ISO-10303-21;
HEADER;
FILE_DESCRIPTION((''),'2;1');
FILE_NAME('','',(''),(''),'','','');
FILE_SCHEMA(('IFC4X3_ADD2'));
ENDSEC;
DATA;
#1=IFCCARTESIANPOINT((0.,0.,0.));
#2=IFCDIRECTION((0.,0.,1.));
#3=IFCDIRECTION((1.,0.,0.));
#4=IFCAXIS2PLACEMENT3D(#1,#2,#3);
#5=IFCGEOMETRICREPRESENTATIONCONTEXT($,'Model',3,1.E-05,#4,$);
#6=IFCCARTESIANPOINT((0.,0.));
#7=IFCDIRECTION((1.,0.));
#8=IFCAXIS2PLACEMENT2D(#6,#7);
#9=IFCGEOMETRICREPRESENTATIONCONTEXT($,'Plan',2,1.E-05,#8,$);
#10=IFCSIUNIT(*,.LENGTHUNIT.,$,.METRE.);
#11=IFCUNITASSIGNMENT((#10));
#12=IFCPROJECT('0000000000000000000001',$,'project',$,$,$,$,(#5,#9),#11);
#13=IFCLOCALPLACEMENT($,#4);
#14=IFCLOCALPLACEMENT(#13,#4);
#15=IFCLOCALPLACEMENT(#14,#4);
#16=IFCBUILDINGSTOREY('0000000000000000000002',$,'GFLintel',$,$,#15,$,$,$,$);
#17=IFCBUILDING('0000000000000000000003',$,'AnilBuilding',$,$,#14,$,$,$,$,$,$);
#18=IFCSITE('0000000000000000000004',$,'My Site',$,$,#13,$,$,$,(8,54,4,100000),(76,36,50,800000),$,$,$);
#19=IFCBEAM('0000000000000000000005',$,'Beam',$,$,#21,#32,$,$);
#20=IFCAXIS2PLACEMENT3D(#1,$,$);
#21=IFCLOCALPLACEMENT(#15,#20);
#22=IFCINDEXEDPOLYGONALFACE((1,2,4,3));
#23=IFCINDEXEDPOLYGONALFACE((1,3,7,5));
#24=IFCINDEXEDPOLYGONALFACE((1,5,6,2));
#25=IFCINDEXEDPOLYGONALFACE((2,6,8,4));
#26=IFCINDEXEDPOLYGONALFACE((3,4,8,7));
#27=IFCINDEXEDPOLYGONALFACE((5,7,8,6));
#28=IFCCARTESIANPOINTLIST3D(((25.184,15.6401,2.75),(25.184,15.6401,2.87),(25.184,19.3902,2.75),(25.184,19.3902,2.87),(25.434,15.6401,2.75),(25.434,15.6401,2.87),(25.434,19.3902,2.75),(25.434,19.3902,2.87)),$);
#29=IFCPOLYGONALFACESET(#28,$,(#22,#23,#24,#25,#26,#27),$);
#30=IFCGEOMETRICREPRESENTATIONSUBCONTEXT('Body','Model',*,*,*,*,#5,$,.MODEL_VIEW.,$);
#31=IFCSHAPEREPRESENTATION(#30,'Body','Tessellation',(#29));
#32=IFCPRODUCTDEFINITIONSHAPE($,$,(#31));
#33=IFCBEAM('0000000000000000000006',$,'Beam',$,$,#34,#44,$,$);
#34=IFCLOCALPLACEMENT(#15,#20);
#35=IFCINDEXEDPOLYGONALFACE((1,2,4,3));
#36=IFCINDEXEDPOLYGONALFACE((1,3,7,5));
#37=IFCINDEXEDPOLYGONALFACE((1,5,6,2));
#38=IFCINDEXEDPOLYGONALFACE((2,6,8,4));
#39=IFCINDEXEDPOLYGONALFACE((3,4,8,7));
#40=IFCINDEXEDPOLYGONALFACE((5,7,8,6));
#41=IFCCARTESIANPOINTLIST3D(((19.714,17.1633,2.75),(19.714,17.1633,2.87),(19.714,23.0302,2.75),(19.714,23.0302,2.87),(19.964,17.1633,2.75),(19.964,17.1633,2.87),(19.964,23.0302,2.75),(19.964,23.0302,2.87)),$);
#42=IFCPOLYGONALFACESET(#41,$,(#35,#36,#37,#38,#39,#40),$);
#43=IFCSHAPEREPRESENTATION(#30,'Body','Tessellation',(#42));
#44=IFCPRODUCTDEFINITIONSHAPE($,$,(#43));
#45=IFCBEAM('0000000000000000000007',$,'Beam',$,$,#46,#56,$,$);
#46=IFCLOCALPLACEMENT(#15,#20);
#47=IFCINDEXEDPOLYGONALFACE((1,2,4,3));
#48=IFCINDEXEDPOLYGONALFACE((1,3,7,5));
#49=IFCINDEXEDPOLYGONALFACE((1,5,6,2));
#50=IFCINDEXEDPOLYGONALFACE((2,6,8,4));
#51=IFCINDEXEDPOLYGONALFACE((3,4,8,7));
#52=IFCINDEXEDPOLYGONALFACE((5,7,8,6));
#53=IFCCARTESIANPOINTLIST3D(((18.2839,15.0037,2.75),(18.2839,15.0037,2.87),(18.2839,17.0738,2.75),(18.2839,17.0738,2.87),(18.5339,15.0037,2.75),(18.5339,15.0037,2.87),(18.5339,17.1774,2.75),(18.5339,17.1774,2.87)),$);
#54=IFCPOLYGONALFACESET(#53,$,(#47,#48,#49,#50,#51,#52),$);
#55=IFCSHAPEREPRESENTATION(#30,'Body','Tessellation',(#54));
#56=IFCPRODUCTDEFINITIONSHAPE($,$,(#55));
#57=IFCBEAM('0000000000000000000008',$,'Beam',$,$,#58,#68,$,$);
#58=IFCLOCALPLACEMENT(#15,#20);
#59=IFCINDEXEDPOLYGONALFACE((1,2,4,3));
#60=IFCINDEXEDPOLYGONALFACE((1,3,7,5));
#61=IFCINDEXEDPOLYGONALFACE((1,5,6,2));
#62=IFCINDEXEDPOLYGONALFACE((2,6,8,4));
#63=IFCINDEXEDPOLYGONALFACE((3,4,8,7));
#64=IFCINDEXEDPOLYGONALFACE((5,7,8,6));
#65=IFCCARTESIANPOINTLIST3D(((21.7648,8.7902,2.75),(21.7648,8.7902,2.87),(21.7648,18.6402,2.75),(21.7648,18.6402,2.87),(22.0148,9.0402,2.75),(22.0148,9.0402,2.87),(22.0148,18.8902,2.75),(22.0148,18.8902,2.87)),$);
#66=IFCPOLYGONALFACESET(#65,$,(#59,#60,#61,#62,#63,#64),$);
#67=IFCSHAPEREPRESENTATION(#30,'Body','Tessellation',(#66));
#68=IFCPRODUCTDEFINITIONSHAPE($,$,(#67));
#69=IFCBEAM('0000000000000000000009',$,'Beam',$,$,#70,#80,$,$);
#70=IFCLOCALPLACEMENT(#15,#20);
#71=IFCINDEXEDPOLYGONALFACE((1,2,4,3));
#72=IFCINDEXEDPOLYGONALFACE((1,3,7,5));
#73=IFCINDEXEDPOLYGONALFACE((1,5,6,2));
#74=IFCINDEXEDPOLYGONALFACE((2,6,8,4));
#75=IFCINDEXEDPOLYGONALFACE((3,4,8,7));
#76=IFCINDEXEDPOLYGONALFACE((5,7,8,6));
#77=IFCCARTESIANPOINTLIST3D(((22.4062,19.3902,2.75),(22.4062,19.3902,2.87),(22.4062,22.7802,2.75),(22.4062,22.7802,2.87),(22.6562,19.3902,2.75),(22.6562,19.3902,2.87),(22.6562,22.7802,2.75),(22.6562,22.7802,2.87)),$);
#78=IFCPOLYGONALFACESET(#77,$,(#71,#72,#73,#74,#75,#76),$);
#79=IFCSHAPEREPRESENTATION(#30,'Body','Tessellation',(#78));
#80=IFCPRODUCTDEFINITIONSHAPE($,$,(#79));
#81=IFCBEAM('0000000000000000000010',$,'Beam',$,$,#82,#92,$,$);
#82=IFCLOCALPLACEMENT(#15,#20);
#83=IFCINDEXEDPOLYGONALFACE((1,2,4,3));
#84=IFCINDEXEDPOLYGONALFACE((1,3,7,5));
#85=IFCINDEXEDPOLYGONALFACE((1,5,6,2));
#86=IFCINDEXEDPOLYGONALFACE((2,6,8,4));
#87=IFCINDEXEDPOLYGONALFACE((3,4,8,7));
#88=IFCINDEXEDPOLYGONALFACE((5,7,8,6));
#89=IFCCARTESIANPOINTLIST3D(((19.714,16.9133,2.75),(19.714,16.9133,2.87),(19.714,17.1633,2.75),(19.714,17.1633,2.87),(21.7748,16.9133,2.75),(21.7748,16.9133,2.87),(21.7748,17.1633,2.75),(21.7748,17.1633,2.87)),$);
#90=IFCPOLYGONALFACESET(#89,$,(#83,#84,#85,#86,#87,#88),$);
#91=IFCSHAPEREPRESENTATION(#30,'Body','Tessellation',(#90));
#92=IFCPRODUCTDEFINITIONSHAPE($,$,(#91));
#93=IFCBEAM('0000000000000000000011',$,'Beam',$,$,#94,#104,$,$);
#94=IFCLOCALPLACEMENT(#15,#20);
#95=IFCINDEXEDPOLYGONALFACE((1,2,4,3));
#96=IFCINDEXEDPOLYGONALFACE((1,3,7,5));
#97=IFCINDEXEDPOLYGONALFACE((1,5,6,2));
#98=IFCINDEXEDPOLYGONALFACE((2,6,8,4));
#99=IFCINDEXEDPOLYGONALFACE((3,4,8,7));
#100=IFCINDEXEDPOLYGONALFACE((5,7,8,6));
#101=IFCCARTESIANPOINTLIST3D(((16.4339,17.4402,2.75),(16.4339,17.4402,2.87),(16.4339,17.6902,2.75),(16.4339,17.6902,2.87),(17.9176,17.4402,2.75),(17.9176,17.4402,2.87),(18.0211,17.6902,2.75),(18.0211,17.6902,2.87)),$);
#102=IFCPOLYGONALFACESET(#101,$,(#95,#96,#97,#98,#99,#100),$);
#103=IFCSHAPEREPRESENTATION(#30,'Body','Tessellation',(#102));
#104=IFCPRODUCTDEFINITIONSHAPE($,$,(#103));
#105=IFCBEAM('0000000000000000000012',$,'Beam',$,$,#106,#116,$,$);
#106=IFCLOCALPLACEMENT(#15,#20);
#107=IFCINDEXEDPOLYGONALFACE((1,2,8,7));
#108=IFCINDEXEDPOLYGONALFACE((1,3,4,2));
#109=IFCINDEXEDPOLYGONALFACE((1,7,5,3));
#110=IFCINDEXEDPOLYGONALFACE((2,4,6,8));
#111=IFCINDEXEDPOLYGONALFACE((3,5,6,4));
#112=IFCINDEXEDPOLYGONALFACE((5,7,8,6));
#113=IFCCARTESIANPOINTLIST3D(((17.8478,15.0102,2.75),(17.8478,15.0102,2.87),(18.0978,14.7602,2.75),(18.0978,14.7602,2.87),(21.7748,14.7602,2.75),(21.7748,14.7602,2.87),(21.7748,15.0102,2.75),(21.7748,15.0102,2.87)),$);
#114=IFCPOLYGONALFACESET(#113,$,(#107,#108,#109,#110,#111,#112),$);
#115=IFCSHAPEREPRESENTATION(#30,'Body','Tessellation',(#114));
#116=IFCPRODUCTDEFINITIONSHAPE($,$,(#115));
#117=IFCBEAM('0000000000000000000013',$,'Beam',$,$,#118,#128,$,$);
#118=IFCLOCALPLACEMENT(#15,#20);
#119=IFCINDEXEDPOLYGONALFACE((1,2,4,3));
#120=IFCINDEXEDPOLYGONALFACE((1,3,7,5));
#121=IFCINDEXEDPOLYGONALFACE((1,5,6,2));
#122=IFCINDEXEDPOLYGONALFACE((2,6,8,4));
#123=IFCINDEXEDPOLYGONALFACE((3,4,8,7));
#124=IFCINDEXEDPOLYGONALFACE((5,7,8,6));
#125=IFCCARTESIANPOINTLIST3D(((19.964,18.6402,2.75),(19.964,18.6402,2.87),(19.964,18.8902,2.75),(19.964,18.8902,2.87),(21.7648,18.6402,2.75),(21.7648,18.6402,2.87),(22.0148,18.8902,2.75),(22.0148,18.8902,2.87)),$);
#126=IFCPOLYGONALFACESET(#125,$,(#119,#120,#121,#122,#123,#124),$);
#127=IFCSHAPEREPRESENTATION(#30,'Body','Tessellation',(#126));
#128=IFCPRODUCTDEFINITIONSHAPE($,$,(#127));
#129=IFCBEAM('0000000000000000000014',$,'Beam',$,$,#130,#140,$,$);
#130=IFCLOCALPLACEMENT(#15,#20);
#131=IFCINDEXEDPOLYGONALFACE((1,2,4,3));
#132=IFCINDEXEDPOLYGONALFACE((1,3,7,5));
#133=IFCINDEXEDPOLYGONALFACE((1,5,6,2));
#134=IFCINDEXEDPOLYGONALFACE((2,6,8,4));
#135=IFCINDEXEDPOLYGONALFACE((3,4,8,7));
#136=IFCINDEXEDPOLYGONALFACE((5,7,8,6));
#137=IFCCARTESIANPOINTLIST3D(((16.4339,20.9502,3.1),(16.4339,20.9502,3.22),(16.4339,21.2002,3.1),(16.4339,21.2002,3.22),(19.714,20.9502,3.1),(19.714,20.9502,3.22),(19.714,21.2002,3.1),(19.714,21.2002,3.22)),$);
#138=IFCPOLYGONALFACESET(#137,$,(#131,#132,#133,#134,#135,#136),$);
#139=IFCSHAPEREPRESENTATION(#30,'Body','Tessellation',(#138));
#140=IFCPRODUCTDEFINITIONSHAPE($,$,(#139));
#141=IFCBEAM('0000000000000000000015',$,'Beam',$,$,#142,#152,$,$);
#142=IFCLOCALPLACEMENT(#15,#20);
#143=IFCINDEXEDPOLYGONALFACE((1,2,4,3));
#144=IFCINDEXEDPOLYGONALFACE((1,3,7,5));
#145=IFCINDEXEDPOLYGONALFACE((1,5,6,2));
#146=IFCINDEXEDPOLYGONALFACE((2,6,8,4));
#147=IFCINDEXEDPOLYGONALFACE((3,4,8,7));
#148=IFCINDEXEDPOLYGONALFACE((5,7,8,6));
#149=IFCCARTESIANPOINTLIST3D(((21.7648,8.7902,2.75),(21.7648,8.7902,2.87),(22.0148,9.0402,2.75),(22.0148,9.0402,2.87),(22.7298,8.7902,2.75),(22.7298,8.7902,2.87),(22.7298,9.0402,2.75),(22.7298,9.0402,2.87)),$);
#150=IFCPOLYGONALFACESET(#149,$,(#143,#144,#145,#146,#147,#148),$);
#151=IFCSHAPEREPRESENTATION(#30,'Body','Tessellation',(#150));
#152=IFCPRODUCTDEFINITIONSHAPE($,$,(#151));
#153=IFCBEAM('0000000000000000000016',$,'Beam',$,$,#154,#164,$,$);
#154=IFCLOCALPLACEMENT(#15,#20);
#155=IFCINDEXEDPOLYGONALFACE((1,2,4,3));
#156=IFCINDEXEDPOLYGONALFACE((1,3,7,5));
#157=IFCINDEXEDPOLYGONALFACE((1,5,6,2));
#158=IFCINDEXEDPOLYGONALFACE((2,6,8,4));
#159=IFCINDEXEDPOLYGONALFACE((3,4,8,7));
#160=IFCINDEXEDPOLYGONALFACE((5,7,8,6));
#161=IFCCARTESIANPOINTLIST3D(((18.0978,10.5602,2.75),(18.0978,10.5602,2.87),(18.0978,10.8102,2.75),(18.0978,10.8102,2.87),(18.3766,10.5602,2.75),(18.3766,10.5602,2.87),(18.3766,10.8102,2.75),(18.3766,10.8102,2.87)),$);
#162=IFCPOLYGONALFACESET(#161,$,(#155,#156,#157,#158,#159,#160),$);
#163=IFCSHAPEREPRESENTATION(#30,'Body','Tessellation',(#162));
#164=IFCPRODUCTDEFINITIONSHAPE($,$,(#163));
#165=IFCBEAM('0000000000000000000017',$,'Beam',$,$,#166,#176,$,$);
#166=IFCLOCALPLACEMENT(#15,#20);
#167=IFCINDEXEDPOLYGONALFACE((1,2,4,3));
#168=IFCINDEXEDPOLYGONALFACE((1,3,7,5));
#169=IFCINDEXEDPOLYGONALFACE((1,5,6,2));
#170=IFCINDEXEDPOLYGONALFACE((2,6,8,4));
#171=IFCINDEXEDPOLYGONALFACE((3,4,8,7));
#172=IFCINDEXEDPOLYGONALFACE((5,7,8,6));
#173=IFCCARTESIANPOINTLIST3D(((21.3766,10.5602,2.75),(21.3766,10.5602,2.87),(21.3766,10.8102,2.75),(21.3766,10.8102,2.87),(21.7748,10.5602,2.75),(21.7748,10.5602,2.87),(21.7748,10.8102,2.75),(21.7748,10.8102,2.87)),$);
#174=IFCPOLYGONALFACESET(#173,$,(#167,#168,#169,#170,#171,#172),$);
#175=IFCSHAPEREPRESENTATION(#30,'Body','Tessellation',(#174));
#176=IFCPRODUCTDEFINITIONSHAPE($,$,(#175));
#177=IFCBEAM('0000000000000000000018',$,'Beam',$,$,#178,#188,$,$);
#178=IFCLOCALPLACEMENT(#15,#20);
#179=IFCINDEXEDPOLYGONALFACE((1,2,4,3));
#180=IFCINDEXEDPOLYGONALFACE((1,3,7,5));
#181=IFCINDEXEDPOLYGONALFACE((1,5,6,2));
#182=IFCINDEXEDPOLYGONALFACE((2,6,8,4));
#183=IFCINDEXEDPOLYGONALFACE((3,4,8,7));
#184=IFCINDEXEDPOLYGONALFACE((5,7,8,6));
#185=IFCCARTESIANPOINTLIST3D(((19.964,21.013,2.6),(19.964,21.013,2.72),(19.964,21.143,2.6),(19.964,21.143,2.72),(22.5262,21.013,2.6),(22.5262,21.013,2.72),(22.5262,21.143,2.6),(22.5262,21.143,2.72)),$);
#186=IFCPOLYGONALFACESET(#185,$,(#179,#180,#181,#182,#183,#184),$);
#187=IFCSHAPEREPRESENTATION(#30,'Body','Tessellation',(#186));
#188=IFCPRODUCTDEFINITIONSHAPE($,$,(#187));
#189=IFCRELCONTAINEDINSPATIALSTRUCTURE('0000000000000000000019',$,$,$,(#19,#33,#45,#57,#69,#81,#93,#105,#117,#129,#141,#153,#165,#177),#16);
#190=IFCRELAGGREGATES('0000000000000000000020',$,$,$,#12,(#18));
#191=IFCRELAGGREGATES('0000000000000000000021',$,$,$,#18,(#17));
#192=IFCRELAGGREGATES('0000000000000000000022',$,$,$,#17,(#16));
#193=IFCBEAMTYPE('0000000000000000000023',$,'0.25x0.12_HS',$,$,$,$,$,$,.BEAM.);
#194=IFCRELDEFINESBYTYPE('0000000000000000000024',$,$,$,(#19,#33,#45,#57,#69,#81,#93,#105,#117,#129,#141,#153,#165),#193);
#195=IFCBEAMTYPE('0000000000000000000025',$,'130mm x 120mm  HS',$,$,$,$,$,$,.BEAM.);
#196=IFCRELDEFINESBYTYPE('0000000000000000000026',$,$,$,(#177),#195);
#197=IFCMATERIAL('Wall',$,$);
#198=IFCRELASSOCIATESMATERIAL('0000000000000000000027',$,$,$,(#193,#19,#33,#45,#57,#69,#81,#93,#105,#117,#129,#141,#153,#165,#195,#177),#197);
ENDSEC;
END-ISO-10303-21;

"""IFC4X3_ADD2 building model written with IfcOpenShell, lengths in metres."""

from ifc_helpers import new_model, si_unit, frame, origin_with_axes, origin_2d_with_axis, place, context, subcontext, project, spatial, rectangle, extrude, clip, halfspace, material, material_profile, profile_set, profile_usage, type_object, element, save


model = new_model("IFC4X3_ADD2")

# Units and contexts
model_context = context("Model", 3, precision=1e-05, world=origin_with_axes())
plan_context = context("Plan", 2, precision=1e-05, world=origin_2d_with_axis())
body_context = subcontext(model_context, "Body", "Model", "MODEL_VIEW")
ifc_project = project(units=[si_unit("LENGTHUNIT", "METRE")], contexts=[model_context, plan_context])

# Site, building, storey
site_placement = place(None, origin_with_axes())
site = spatial("IfcSite", under=ifc_project, at=site_placement, Name="My Site", RefLatitude=(8, 54, 4, 100000), RefLongitude=(76, 36, 50, 800000))
building_placement = place(site_placement, origin_with_axes())
building = spatial("IfcBuilding", under=site, at=building_placement, Name="AnilBuilding")
storey_placement = place(building_placement, origin_with_axes())
storey = spatial("IfcBuildingStorey", under=building, at=storey_placement, Name="GFLintel")

# Beams
ifc_material_1 = material(Name="Wall")
ifc_material_profile_1 = material_profile(ifc_material_1, rectangle(XDim=0.25, YDim=0.12))
ifc_profile_set_1 = profile_set([ifc_material_profile_1], Name="concrete")
ifc_profile_usage_1 = profile_usage(ifc_profile_set_1)
beam_type_1 = type_object("IfcBeamType", Name="0.25x0.12_HS", PredefinedType="BEAM", material=ifc_profile_set_1)
beam_1_placement = place(storey_placement, frame((25.309, 19.3902, 2.81), z_axis=(0.0, -1.0, 0.0), x_axis=(1.0, 0.0, 0.0)))
element("IfcBeam", 1, at=beam_1_placement, inside=storey, type_object=beam_type_1, material=ifc_profile_usage_1, Name="Beam", context=body_context, shape_type="SweptSolid", body=[
    extrude(rectangle(XDim=0.25, YDim=0.12), origin_with_axes(), (0.0, 0.0, 1.0), 3.7501),
])
ifc_profile_usage_2 = profile_usage(ifc_profile_set_1)
beam_2_placement = place(storey_placement, frame((19.839, 23.0302, 2.81), z_axis=(0.0, -1.0, 0.0), x_axis=(1.0, 0.0, 0.0)))
element("IfcBeam", 2, at=beam_2_placement, inside=storey, type_object=beam_type_1, material=ifc_profile_usage_2, Name="Beam", context=body_context, shape_type="SweptSolid", body=[
    extrude(rectangle(XDim=0.25, YDim=0.12), origin_with_axes(), (0.0, 0.0, 1.0), 5.8669),
])
ifc_profile_usage_3 = profile_usage(ifc_profile_set_1)
beam_3_placement = place(storey_placement, frame((18.4089, 17.5524, 2.81), z_axis=(0.0, -1.0, 0.0), x_axis=(1.0, 0.0, 0.0)))
element("IfcBeam", 3, at=beam_3_placement, inside=storey, type_object=beam_type_1, material=ifc_profile_usage_3, Name="Beam", context=body_context, shape_type="Clipping", body=[
    clip(extrude(rectangle(XDim=0.25, YDim=0.12), origin_with_axes(), (0.0, 0.0, 1.0), 2.5487), halfspace(frame((0.125, -2.81, 0.375), z_axis=(-0.382687, 0.0, -0.923878), x_axis=(0.000001, 1.0, 0.0)), False)),
])
ifc_profile_usage_4 = profile_usage(ifc_profile_set_1)
beam_4_placement = place(storey_placement, frame((21.8898, 18.8902, 2.81), z_axis=(0.0, -1.0, 0.0), x_axis=(1.0, 0.0, 0.0)))
element("IfcBeam", 4, at=beam_4_placement, inside=storey, type_object=beam_type_1, material=ifc_profile_usage_4, Name="Beam", context=body_context, shape_type="Clipping", body=[
    clip(clip(extrude(rectangle(XDim=0.25, YDim=0.12), origin_with_axes(), (0.0, 0.0, 1.0), 10.1), halfspace(frame((-0.125, -2.66, 10.1), z_axis=(0.707107, 0.0, 0.707107), x_axis=(0.0, -1.0, 0.0)), False)), halfspace(frame((0.125, -2.66, 0.0), z_axis=(-0.707104, 0.0, -0.707109), x_axis=(0.0, 1.0, 0.0)), False)),
])
ifc_profile_usage_5 = profile_usage(ifc_profile_set_1)
beam_5_placement = place(storey_placement, frame((22.5312, 19.3902, 2.81), z_axis=(0.000001, 1.0, 0.0), x_axis=(-1.0, 0.000001, 0.0)))
element("IfcBeam", 5, at=beam_5_placement, inside=storey, type_object=beam_type_1, material=ifc_profile_usage_5, Name="Beam", context=body_context, shape_type="SweptSolid", body=[
    extrude(rectangle(XDim=0.25, YDim=0.12), origin_with_axes(), (0.0, 0.0, 1.0), 3.39),
])
ifc_profile_usage_6 = profile_usage(ifc_profile_set_1)
beam_6_placement = place(storey_placement, frame((21.7748, 17.0383, 2.81), z_axis=(-1.0, 0.0, 0.0), x_axis=(0.0, -1.0, 0.0)))
element("IfcBeam", 6, at=beam_6_placement, inside=storey, type_object=beam_type_1, material=ifc_profile_usage_6, Name="Beam", context=body_context, shape_type="SweptSolid", body=[
    extrude(rectangle(XDim=0.25, YDim=0.12), origin_with_axes(), (0.0, 0.0, 1.0), 2.0608),
])
ifc_profile_usage_7 = profile_usage(ifc_profile_set_1)
beam_7_placement = place(storey_placement, frame((18.3961, 17.5652, 2.81), z_axis=(-1.0, 0.0, 0.0), x_axis=(0.0, -1.0, 0.0)))
element("IfcBeam", 7, at=beam_7_placement, inside=storey, type_object=beam_type_1, material=ifc_profile_usage_7, Name="Beam", context=body_context, shape_type="Clipping", body=[
    clip(extrude(rectangle(XDim=0.25, YDim=0.12), origin_with_axes(), (0.0, 0.0, 1.0), 1.9622), halfspace(frame((-0.125, -2.81, 0.375), z_axis=(0.382685, 0.000001, -0.923879), x_axis=(0.000002, -1.0, 0.0)), False)),
])
ifc_profile_usage_8 = profile_usage(ifc_profile_set_1)
beam_8_placement = place(storey_placement, frame((21.7748, 14.8852, 2.81), z_axis=(-1.0, 0.0, 0.0), x_axis=(0.0, -1.0, 0.0)))
element("IfcBeam", 8, at=beam_8_placement, inside=storey, type_object=beam_type_1, material=ifc_profile_usage_8, Name="Beam", context=body_context, shape_type="Clipping", body=[
    clip(extrude(rectangle(XDim=0.25, YDim=0.12), origin_with_axes(), (0.0, 0.0, 1.0), 3.927), halfspace(frame((-0.125, -2.81, 3.927), z_axis=(0.707107, 0.0, 0.707107), x_axis=(0.0, -1.0, 0.0)), False)),
])
ifc_profile_usage_9 = profile_usage(ifc_profile_set_1)
beam_9_placement = place(storey_placement, frame((22.0148, 18.7652, 2.81), z_axis=(-1.0, 0.0, 0.0), x_axis=(0.0, -1.0, 0.0)))
element("IfcBeam", 9, at=beam_9_placement, inside=storey, type_object=beam_type_1, material=ifc_profile_usage_9, Name="Beam", context=body_context, shape_type="Clipping", body=[
    clip(extrude(rectangle(XDim=0.25, YDim=0.12), origin_with_axes(), (0.0, 0.0, 1.0), 2.0508), halfspace(frame((-0.125, -2.66, 0.0), z_axis=(0.70711, 0.0, -0.707104), x_axis=(0.0, -1.0, 0.0)), False)),
])
ifc_profile_usage_10 = profile_usage(ifc_profile_set_1)
beam_10_placement = place(storey_placement, frame((19.714, 21.0752, 3.16), z_axis=(-1.0, 0.0, 0.0), x_axis=(0.0, -1.0, 0.0)))
element("IfcBeam", 10, at=beam_10_placement, inside=storey, type_object=beam_type_1, material=ifc_profile_usage_10, Name="Beam", context=body_context, shape_type="SweptSolid", body=[
    extrude(rectangle(XDim=0.25, YDim=0.12), origin_with_axes(), (0.0, 0.0, 1.0), 3.28),
])
ifc_profile_usage_11 = profile_usage(ifc_profile_set_1)
beam_11_placement = place(storey_placement, frame((22.7298, 8.9152, 2.81), z_axis=(-1.0, 0.000001, 0.0), x_axis=(-0.000001, -1.0, 0.0)))
element("IfcBeam", 11, at=beam_11_placement, inside=storey, type_object=beam_type_1, material=ifc_profile_usage_11, Name="Beam", context=body_context, shape_type="Clipping", body=[
    clip(extrude(rectangle(XDim=0.25, YDim=0.12), origin_with_axes(), (0.0, 0.0, 1.0), 0.965), halfspace(frame((0.125, -2.66, 0.965), z_axis=(-0.707106, 0.0, 0.707107), x_axis=(0.0, 1.0, 0.0)), False)),
])
ifc_profile_usage_12 = profile_usage(ifc_profile_set_1)
beam_12_placement = place(storey_placement, frame((18.3766, 10.6852, 2.81), z_axis=(-1.0, 0.000001, 0.0), x_axis=(-0.000001, -1.0, 0.0)))
element("IfcBeam", 12, at=beam_12_placement, inside=storey, type_object=beam_type_1, material=ifc_profile_usage_12, Name="Beam", context=body_context, shape_type="SweptSolid", body=[
    extrude(rectangle(XDim=0.25, YDim=0.12), origin_with_axes(), (0.0, 0.0, 1.0), 0.2788),
])
ifc_profile_usage_13 = profile_usage(ifc_profile_set_1)
beam_13_placement = place(storey_placement, frame((21.7748, 10.6852, 2.81), z_axis=(-1.0, 0.000001, 0.0), x_axis=(-0.000001, -1.0, 0.0)))
element("IfcBeam", 13, at=beam_13_placement, inside=storey, type_object=beam_type_1, material=ifc_profile_usage_13, Name="Beam", context=body_context, shape_type="SweptSolid", body=[
    extrude(rectangle(XDim=0.25, YDim=0.12), origin_with_axes(), (0.0, 0.0, 1.0), 0.3982),
])
ifc_material_profile_2 = material_profile(ifc_material_1, rectangle(XDim=0.13, YDim=0.12))
ifc_profile_set_2 = profile_set([ifc_material_profile_2], Name="concrete")
ifc_profile_usage_14 = profile_usage(ifc_profile_set_2)
beam_type_2 = type_object("IfcBeamType", Name="130mm x 120mm  HS", PredefinedType="BEAM", material=ifc_profile_set_2)
beam_14_placement = place(storey_placement, frame((22.5262, 21.078, 2.66), z_axis=(-1.0, 0.000001, 0.0), x_axis=(-0.000001, -1.0, 0.0)))
element("IfcBeam", 14, at=beam_14_placement, inside=storey, type_object=beam_type_2, material=ifc_profile_usage_14, Name="Beam", context=body_context, shape_type="SweptSolid", body=[
    extrude(rectangle(XDim=0.13, YDim=0.12), origin_with_axes(), (0.0, 0.0, 1.0), 2.5622),
])

save(model, "model.ifc")
